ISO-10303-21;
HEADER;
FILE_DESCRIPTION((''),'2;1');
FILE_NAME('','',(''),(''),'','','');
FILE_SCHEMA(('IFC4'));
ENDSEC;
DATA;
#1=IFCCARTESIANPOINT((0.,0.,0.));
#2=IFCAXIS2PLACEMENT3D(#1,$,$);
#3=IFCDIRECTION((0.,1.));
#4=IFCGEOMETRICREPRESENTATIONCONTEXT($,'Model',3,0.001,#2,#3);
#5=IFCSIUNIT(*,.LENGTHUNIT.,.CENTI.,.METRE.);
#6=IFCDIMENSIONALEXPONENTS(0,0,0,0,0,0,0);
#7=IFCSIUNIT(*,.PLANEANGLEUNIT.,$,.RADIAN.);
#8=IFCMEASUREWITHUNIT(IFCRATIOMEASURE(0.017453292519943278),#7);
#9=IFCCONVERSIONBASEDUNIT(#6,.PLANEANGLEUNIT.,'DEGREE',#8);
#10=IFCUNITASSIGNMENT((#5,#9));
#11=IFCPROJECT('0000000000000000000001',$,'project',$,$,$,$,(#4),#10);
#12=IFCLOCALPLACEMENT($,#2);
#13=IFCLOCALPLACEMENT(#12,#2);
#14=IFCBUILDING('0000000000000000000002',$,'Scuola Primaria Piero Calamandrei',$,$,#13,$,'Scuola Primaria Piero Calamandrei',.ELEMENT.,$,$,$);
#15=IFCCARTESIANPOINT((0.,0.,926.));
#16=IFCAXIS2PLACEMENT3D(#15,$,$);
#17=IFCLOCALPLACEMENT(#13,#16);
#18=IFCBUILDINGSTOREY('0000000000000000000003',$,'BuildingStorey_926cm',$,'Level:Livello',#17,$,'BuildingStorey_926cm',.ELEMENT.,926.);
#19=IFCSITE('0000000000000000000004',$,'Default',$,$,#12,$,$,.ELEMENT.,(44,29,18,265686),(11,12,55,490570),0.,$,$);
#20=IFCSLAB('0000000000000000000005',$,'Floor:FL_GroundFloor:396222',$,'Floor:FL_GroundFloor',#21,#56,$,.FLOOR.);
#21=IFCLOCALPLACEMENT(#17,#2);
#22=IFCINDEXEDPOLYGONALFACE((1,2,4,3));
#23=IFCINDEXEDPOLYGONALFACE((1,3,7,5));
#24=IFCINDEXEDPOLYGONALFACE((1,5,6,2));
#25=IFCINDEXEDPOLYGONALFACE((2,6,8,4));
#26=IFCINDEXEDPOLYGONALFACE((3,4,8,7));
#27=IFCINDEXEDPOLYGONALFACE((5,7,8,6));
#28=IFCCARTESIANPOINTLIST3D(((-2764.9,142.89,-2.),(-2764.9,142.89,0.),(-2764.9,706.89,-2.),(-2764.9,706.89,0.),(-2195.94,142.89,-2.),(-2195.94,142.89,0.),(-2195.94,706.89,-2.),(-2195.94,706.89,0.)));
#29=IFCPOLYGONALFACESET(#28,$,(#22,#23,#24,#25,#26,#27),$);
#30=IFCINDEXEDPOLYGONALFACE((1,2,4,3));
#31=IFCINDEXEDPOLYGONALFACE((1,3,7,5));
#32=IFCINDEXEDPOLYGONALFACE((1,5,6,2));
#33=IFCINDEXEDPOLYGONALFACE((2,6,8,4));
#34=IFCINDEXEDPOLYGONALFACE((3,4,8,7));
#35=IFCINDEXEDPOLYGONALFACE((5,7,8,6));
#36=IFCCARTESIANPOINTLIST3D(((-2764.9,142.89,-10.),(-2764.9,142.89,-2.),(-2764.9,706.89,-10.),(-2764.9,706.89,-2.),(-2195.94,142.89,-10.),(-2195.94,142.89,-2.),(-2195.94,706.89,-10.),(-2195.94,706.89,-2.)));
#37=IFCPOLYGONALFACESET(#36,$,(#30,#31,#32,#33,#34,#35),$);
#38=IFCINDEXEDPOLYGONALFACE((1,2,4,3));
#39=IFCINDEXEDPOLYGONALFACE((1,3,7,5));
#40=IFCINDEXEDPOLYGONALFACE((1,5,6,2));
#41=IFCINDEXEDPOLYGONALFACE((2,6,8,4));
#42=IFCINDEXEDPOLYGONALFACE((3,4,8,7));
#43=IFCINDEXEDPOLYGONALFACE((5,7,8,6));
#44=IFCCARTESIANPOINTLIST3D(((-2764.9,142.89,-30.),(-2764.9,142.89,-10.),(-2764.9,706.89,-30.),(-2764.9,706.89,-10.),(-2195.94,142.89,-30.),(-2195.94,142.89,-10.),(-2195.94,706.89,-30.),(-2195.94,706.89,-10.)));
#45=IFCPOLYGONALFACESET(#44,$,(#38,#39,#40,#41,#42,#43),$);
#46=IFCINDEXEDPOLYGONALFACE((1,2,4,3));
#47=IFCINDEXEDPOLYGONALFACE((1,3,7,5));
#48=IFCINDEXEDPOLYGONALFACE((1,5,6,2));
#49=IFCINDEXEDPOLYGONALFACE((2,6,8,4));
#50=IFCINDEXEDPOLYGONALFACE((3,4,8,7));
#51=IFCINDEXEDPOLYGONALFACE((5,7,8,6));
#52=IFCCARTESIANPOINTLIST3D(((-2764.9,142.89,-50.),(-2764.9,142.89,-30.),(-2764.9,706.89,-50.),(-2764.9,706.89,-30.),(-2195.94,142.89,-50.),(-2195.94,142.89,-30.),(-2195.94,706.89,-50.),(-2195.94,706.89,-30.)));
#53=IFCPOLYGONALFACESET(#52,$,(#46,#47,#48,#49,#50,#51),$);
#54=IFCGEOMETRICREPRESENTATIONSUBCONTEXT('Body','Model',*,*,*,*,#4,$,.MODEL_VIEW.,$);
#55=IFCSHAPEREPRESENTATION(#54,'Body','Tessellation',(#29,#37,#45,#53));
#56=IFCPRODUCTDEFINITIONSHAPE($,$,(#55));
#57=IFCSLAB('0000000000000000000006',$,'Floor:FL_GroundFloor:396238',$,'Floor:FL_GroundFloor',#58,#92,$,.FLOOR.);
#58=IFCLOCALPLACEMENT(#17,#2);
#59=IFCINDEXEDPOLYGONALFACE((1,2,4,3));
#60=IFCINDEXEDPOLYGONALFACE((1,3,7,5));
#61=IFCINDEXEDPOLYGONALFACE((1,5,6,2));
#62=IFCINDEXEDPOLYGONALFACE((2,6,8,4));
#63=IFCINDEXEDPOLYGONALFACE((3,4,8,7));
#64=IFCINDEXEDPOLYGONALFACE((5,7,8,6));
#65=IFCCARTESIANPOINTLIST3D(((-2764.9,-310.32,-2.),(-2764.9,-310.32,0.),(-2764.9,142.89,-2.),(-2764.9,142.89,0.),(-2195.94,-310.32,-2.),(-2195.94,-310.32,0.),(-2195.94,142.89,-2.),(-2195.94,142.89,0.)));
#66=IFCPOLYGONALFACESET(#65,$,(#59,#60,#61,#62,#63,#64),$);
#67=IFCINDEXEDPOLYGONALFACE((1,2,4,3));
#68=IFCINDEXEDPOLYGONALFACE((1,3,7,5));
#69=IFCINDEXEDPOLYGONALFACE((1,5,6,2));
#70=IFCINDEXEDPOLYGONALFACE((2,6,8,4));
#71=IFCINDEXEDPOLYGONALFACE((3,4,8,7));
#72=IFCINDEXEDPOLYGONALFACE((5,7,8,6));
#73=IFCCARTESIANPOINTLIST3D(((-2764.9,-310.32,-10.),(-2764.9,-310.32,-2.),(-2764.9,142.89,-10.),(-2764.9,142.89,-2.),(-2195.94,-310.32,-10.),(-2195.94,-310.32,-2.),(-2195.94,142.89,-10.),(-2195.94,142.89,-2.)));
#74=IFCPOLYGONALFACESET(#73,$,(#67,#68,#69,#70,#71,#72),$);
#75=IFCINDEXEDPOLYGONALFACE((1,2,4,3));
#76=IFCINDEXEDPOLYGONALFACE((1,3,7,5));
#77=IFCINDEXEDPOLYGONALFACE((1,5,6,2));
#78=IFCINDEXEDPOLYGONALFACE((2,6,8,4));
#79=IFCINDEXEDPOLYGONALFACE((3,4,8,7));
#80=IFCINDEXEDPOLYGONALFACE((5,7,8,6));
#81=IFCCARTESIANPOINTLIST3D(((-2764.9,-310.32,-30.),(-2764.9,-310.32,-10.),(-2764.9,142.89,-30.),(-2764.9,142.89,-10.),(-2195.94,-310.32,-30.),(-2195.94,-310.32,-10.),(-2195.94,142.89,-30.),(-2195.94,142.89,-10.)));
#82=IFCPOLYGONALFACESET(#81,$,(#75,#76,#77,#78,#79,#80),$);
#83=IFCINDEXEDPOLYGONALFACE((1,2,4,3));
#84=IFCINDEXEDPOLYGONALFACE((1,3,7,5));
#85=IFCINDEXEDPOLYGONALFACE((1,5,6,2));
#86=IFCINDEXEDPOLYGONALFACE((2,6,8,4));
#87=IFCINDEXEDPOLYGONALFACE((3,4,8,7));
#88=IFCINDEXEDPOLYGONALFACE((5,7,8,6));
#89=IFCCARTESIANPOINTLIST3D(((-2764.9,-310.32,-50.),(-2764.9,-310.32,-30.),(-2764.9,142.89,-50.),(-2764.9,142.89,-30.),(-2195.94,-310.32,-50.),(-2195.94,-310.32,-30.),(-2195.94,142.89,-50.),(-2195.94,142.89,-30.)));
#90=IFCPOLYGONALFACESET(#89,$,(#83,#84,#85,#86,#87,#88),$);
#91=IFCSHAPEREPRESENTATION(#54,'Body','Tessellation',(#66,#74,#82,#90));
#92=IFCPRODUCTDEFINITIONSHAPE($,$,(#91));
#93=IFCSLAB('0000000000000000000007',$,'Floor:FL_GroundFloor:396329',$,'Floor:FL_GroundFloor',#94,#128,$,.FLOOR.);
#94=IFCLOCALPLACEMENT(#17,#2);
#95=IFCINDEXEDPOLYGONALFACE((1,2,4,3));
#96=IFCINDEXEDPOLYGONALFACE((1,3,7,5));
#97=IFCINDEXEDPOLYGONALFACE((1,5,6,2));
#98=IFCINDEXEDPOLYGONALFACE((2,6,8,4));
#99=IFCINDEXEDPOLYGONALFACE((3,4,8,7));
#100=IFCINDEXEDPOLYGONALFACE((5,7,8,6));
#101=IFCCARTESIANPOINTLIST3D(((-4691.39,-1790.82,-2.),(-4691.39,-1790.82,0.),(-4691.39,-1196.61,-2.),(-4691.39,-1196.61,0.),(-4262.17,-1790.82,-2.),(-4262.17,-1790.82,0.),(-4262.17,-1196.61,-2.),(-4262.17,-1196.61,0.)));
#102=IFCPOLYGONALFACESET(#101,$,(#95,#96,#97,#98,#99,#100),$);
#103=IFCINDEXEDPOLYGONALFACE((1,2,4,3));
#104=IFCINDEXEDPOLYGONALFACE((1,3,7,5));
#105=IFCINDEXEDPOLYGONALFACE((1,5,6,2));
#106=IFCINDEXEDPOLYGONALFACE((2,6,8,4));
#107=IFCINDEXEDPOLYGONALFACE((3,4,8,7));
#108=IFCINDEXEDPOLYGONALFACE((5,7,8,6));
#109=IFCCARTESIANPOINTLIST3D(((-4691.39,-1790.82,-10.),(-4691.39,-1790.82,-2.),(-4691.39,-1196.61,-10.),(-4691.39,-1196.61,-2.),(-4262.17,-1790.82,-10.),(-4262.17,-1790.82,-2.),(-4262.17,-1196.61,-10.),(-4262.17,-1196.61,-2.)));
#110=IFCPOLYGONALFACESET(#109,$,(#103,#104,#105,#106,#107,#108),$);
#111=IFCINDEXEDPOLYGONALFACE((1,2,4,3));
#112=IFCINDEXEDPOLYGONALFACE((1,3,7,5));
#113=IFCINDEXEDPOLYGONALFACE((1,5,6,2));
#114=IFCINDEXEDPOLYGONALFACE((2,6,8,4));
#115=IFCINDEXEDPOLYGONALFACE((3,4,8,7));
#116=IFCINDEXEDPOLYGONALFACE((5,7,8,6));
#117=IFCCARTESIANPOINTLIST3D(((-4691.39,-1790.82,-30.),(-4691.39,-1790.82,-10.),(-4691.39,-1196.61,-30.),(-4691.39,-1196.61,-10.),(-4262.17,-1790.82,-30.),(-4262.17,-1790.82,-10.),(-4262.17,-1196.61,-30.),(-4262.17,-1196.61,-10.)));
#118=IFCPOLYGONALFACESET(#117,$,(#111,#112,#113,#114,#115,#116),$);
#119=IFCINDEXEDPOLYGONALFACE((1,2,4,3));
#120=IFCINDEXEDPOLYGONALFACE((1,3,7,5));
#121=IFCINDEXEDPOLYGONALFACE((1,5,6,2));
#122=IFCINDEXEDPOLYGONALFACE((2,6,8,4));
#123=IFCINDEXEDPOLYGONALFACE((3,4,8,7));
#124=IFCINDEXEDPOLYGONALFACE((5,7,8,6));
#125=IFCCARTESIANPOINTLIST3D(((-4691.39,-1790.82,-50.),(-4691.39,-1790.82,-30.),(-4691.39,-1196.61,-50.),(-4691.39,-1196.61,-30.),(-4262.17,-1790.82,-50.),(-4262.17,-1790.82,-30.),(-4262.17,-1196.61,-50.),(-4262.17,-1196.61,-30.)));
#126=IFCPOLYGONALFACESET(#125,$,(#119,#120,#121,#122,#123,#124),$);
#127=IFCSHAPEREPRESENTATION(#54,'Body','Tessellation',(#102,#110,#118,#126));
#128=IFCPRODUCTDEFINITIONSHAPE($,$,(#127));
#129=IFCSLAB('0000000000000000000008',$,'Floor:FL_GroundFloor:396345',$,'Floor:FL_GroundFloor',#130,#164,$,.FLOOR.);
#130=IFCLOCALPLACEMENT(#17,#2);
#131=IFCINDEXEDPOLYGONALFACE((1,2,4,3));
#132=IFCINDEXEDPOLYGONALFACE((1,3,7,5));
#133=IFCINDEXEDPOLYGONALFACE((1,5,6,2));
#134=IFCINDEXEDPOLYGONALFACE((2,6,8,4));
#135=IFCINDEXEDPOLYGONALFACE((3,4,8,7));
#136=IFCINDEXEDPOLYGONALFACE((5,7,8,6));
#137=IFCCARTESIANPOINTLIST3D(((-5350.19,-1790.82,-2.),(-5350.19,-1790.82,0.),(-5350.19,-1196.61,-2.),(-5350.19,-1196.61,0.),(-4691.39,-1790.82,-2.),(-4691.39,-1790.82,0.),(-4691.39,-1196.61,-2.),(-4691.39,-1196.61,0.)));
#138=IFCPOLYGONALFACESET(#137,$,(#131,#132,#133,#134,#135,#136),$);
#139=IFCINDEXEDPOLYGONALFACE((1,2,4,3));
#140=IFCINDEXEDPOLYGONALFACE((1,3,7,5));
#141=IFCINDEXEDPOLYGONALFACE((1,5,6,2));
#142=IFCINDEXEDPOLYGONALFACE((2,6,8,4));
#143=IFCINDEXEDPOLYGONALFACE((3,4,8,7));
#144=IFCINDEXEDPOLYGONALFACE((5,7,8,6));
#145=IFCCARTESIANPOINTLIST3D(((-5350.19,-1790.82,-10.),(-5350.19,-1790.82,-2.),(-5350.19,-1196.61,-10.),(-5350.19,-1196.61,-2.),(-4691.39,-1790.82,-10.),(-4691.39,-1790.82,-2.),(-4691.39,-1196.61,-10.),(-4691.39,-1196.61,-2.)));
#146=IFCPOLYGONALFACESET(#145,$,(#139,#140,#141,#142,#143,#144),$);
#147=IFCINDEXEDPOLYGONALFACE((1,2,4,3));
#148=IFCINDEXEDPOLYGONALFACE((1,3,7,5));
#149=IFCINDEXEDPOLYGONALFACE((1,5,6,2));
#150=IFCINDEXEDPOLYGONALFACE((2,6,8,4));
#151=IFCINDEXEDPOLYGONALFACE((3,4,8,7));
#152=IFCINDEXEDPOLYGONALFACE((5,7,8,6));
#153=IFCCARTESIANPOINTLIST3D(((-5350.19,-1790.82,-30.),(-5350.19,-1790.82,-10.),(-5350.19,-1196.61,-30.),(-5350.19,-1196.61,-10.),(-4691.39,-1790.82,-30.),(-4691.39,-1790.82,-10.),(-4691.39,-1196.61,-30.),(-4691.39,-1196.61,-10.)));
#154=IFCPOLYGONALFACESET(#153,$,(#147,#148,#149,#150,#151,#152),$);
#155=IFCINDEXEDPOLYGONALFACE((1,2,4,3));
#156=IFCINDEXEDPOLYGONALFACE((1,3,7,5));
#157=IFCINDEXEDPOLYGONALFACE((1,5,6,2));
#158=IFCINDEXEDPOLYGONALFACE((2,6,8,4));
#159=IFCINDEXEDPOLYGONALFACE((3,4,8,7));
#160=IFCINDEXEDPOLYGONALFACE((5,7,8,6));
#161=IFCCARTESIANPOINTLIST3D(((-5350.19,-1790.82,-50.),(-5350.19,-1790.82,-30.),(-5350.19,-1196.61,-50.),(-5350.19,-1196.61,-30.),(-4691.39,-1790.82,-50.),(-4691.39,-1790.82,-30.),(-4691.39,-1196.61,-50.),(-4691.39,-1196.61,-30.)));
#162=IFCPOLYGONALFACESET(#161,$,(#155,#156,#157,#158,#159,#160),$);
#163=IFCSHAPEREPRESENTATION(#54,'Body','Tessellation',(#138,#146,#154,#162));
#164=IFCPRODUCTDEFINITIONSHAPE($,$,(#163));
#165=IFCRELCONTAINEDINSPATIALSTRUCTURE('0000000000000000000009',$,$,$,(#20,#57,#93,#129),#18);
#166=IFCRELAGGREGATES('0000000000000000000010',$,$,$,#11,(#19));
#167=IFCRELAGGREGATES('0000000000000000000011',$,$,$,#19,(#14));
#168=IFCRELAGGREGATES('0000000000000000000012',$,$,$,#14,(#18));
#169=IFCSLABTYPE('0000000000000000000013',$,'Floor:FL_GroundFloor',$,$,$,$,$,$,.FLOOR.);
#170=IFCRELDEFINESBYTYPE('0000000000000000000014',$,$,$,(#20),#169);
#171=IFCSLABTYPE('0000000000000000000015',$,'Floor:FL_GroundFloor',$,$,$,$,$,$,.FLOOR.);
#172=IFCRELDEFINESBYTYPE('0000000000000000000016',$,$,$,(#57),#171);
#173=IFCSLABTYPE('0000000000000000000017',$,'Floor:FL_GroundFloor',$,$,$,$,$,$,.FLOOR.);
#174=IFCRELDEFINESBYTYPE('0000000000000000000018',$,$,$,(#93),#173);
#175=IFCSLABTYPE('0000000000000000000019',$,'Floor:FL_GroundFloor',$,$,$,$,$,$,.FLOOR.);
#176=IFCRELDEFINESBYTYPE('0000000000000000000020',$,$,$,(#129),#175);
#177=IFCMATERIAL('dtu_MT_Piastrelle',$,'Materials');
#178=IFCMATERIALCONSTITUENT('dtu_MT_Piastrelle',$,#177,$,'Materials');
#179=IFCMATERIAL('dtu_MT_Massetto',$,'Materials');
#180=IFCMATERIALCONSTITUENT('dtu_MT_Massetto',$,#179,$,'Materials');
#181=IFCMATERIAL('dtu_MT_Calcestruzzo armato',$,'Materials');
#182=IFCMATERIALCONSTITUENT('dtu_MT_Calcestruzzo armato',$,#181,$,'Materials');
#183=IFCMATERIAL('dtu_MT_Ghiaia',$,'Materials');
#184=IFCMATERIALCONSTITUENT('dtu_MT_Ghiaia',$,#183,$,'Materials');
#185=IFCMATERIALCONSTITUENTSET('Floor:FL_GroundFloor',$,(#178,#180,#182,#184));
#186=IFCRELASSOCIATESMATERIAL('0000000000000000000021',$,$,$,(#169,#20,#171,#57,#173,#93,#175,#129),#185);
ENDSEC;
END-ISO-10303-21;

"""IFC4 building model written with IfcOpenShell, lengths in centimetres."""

from ifc_helpers import new_model, entity, si_unit, converted_unit, direction, frame, origin, place, context, subcontext, project, spatial, indexed_curve, outline, extrude, material, constituent, constituent_set, type_object, element, save


model = new_model("IFC4")

# Units and contexts
model_context = context("Model", 3, precision=0.001, world=origin(), true_north=direction((0.0, 1.0)))
body_context = subcontext(model_context, "Body", "Model", "MODEL_VIEW")
ifc_project = project(units=[si_unit("LENGTHUNIT", "METRE", prefix="CENTI"), converted_unit("PLANEANGLEUNIT", "DEGREE", entity("IfcRatioMeasure", 0.017453292519943278), si_unit("PLANEANGLEUNIT", "RADIAN"), dimensions=[0, 0, 0, 0, 0, 0, 0])], contexts=[model_context])

# Site, building, storey
site_placement = place(None, origin())
site = spatial("IfcSite", under=ifc_project, at=site_placement, Name="Default", CompositionType="ELEMENT", RefLatitude=(44, 29, 18, 265686), RefLongitude=(11, 12, 55, 490570), RefElevation=0.0)
building_placement = place(site_placement, origin())
building = spatial("IfcBuilding", under=site, at=building_placement, Name="Scuola Primaria Piero Calamandrei", LongName="Scuola Primaria Piero Calamandrei", CompositionType="ELEMENT")
storey_placement = place(building_placement, frame((0.0, 0.0, 926.0)))
storey = spatial("IfcBuildingStorey", under=building, at=storey_placement, Name="BuildingStorey_926cm", ObjectType="Level:Livello", LongName="BuildingStorey_926cm", CompositionType="ELEMENT", Elevation=926.0)

# Slabs
ifc_material_1 = material(Name="dtu_MT_Piastrelle", Category="Materials")
ifc_constituent_1 = constituent(ifc_material_1, Name="dtu_MT_Piastrelle", Category="Materials")
ifc_material_2 = material(Name="dtu_MT_Massetto", Category="Materials")
ifc_constituent_2 = constituent(ifc_material_2, Name="dtu_MT_Massetto", Category="Materials")
ifc_material_3 = material(Name="dtu_MT_Calcestruzzo armato", Category="Materials")
ifc_constituent_3 = constituent(ifc_material_3, Name="dtu_MT_Calcestruzzo armato", Category="Materials")
ifc_material_4 = material(Name="dtu_MT_Ghiaia", Category="Materials")
ifc_constituent_4 = constituent(ifc_material_4, Name="dtu_MT_Ghiaia", Category="Materials")
ifc_constituent_set_1 = constituent_set(constituents=[ifc_constituent_1, ifc_constituent_2, ifc_constituent_3, ifc_constituent_4], Name="Floor:FL_GroundFloor")
slab_type_1 = type_object("IfcSlabType", Name="Floor:FL_GroundFloor", PredefinedType="FLOOR", material=ifc_constituent_set_1)
slab_1_placement = place(storey_placement, origin())
element("IfcSlab", 1, at=slab_1_placement, inside=storey, type_object=slab_type_1, material=ifc_constituent_set_1, Name="Floor:FL_GroundFloor:396222", ObjectType="Floor:FL_GroundFloor", PredefinedType="FLOOR", context=body_context, shape_type="SweptSolid", body=[
    extrude(outline(indexed_curve([(-282.0, -284.48), (282.0, -284.48), (282.0, 284.48), (-282.0, 284.48), (-282.0, -284.48)], self_intersect=False)), frame((-2480.42, 424.89, -2.0), z_axis=(0.0, 0.0, 1.0), x_axis=(0.0, 1.0, 0.0)), (0.0, 0.0, 1.0), 2.0),
    extrude(outline(indexed_curve([(-282.0, -284.48), (282.0, -284.48), (282.0, 284.48), (-282.0, 284.48), (-282.0, -284.48)], self_intersect=False)), frame((-2480.42, 424.89, -10.0), z_axis=(0.0, 0.0, 1.0), x_axis=(0.0, 1.0, 0.0)), (0.0, 0.0, 1.0), 8.0),
    extrude(outline(indexed_curve([(-282.0, -284.48), (282.0, -284.48), (282.0, 284.48), (-282.0, 284.48), (-282.0, -284.48)], self_intersect=False)), frame((-2480.42, 424.89, -30.0), z_axis=(0.0, 0.0, 1.0), x_axis=(0.0, 1.0, 0.0)), (0.0, 0.0, 1.0), 20.0),
    extrude(outline(indexed_curve([(-282.0, -284.48), (282.0, -284.48), (282.0, 284.48), (-282.0, 284.48), (-282.0, -284.48)], self_intersect=False)), frame((-2480.42, 424.89, -50.0), z_axis=(0.0, 0.0, 1.0), x_axis=(0.0, 1.0, 0.0)), (0.0, 0.0, 1.0), 20.0),
])
slab_type_2 = type_object("IfcSlabType", Name="Floor:FL_GroundFloor", PredefinedType="FLOOR", material=ifc_constituent_set_1)
slab_2_placement = place(storey_placement, origin())
element("IfcSlab", 2, at=slab_2_placement, inside=storey, type_object=slab_type_2, material=ifc_constituent_set_1, Name="Floor:FL_GroundFloor:396238", ObjectType="Floor:FL_GroundFloor", PredefinedType="FLOOR", context=body_context, shape_type="SweptSolid", body=[
    extrude(outline(indexed_curve([(-226.61, -284.48), (226.61, -284.48), (226.61, 284.48), (-226.61, 284.48), (-226.61, -284.48)], self_intersect=False)), frame((-2480.42, -83.72, -2.0), z_axis=(0.0, 0.0, 1.0), x_axis=(0.0, 1.0, 0.0)), (0.0, 0.0, 1.0), 2.0),
    extrude(outline(indexed_curve([(-226.61, -284.48), (226.61, -284.48), (226.61, 284.48), (-226.61, 284.48), (-226.61, -284.48)], self_intersect=False)), frame((-2480.42, -83.72, -10.0), z_axis=(0.0, 0.0, 1.0), x_axis=(0.0, 1.0, 0.0)), (0.0, 0.0, 1.0), 8.0),
    extrude(outline(indexed_curve([(-226.61, -284.48), (226.61, -284.48), (226.61, 284.48), (-226.61, 284.48), (-226.61, -284.48)], self_intersect=False)), frame((-2480.42, -83.72, -30.0), z_axis=(0.0, 0.0, 1.0), x_axis=(0.0, 1.0, 0.0)), (0.0, 0.0, 1.0), 20.0),
    extrude(outline(indexed_curve([(-226.61, -284.48), (226.61, -284.48), (226.61, 284.48), (-226.61, 284.48), (-226.61, -284.48)], self_intersect=False)), frame((-2480.42, -83.72, -50.0), z_axis=(0.0, 0.0, 1.0), x_axis=(0.0, 1.0, 0.0)), (0.0, 0.0, 1.0), 20.0),
])
slab_type_3 = type_object("IfcSlabType", Name="Floor:FL_GroundFloor", PredefinedType="FLOOR", material=ifc_constituent_set_1)
slab_3_placement = place(storey_placement, origin())
element("IfcSlab", 3, at=slab_3_placement, inside=storey, type_object=slab_type_3, material=ifc_constituent_set_1, Name="Floor:FL_GroundFloor:396329", ObjectType="Floor:FL_GroundFloor", PredefinedType="FLOOR", context=body_context, shape_type="SweptSolid", body=[
    extrude(outline(indexed_curve([(-297.11, -214.61), (297.11, -214.61), (297.11, 214.61), (-297.11, 214.61), (-297.11, -214.61)], self_intersect=False)), frame((-4476.78, -1493.71, -2.0), z_axis=(0.0, 0.0, 1.0), x_axis=(0.0, 1.0, 0.0)), (0.0, 0.0, 1.0), 2.0),
    extrude(outline(indexed_curve([(-297.11, -214.61), (297.11, -214.61), (297.11, 214.61), (-297.11, 214.61), (-297.11, -214.61)], self_intersect=False)), frame((-4476.78, -1493.71, -10.0), z_axis=(0.0, 0.0, 1.0), x_axis=(0.0, 1.0, 0.0)), (0.0, 0.0, 1.0), 8.0),
    extrude(outline(indexed_curve([(-297.11, -214.61), (297.11, -214.61), (297.11, 214.61), (-297.11, 214.61), (-297.11, -214.61)], self_intersect=False)), frame((-4476.78, -1493.71, -30.0), z_axis=(0.0, 0.0, 1.0), x_axis=(0.0, 1.0, 0.0)), (0.0, 0.0, 1.0), 20.0),
    extrude(outline(indexed_curve([(-297.11, -214.61), (297.11, -214.61), (297.11, 214.61), (-297.11, 214.61), (-297.11, -214.61)], self_intersect=False)), frame((-4476.78, -1493.71, -50.0), z_axis=(0.0, 0.0, 1.0), x_axis=(0.0, 1.0, 0.0)), (0.0, 0.0, 1.0), 20.0),
])
slab_type_4 = type_object("IfcSlabType", Name="Floor:FL_GroundFloor", PredefinedType="FLOOR", material=ifc_constituent_set_1)
slab_4_placement = place(storey_placement, origin())
element("IfcSlab", 4, at=slab_4_placement, inside=storey, type_object=slab_type_4, material=ifc_constituent_set_1, Name="Floor:FL_GroundFloor:396345", ObjectType="Floor:FL_GroundFloor", PredefinedType="FLOOR", context=body_context, shape_type="SweptSolid", body=[
    extrude(outline(indexed_curve([(-297.11, -329.4), (297.11, -329.4), (297.11, 329.4), (-297.11, 329.4), (-297.11, -329.4)], self_intersect=False)), frame((-5020.79, -1493.71, -2.0), z_axis=(0.0, 0.0, 1.0), x_axis=(0.0, 1.0, 0.0)), (0.0, 0.0, 1.0), 2.0),
    extrude(outline(indexed_curve([(-297.11, -329.4), (297.11, -329.4), (297.11, 329.4), (-297.11, 329.4), (-297.11, -329.4)], self_intersect=False)), frame((-5020.79, -1493.71, -10.0), z_axis=(0.0, 0.0, 1.0), x_axis=(0.0, 1.0, 0.0)), (0.0, 0.0, 1.0), 8.0),
    extrude(outline(indexed_curve([(-297.11, -329.4), (297.11, -329.4), (297.11, 329.4), (-297.11, 329.4), (-297.11, -329.4)], self_intersect=False)), frame((-5020.79, -1493.71, -30.0), z_axis=(0.0, 0.0, 1.0), x_axis=(0.0, 1.0, 0.0)), (0.0, 0.0, 1.0), 20.0),
    extrude(outline(indexed_curve([(-297.11, -329.4), (297.11, -329.4), (297.11, 329.4), (-297.11, 329.4), (-297.11, -329.4)], self_intersect=False)), frame((-5020.79, -1493.71, -50.0), z_axis=(0.0, 0.0, 1.0), x_axis=(0.0, 1.0, 0.0)), (0.0, 0.0, 1.0), 20.0),
])

save(model, "model.ifc")
